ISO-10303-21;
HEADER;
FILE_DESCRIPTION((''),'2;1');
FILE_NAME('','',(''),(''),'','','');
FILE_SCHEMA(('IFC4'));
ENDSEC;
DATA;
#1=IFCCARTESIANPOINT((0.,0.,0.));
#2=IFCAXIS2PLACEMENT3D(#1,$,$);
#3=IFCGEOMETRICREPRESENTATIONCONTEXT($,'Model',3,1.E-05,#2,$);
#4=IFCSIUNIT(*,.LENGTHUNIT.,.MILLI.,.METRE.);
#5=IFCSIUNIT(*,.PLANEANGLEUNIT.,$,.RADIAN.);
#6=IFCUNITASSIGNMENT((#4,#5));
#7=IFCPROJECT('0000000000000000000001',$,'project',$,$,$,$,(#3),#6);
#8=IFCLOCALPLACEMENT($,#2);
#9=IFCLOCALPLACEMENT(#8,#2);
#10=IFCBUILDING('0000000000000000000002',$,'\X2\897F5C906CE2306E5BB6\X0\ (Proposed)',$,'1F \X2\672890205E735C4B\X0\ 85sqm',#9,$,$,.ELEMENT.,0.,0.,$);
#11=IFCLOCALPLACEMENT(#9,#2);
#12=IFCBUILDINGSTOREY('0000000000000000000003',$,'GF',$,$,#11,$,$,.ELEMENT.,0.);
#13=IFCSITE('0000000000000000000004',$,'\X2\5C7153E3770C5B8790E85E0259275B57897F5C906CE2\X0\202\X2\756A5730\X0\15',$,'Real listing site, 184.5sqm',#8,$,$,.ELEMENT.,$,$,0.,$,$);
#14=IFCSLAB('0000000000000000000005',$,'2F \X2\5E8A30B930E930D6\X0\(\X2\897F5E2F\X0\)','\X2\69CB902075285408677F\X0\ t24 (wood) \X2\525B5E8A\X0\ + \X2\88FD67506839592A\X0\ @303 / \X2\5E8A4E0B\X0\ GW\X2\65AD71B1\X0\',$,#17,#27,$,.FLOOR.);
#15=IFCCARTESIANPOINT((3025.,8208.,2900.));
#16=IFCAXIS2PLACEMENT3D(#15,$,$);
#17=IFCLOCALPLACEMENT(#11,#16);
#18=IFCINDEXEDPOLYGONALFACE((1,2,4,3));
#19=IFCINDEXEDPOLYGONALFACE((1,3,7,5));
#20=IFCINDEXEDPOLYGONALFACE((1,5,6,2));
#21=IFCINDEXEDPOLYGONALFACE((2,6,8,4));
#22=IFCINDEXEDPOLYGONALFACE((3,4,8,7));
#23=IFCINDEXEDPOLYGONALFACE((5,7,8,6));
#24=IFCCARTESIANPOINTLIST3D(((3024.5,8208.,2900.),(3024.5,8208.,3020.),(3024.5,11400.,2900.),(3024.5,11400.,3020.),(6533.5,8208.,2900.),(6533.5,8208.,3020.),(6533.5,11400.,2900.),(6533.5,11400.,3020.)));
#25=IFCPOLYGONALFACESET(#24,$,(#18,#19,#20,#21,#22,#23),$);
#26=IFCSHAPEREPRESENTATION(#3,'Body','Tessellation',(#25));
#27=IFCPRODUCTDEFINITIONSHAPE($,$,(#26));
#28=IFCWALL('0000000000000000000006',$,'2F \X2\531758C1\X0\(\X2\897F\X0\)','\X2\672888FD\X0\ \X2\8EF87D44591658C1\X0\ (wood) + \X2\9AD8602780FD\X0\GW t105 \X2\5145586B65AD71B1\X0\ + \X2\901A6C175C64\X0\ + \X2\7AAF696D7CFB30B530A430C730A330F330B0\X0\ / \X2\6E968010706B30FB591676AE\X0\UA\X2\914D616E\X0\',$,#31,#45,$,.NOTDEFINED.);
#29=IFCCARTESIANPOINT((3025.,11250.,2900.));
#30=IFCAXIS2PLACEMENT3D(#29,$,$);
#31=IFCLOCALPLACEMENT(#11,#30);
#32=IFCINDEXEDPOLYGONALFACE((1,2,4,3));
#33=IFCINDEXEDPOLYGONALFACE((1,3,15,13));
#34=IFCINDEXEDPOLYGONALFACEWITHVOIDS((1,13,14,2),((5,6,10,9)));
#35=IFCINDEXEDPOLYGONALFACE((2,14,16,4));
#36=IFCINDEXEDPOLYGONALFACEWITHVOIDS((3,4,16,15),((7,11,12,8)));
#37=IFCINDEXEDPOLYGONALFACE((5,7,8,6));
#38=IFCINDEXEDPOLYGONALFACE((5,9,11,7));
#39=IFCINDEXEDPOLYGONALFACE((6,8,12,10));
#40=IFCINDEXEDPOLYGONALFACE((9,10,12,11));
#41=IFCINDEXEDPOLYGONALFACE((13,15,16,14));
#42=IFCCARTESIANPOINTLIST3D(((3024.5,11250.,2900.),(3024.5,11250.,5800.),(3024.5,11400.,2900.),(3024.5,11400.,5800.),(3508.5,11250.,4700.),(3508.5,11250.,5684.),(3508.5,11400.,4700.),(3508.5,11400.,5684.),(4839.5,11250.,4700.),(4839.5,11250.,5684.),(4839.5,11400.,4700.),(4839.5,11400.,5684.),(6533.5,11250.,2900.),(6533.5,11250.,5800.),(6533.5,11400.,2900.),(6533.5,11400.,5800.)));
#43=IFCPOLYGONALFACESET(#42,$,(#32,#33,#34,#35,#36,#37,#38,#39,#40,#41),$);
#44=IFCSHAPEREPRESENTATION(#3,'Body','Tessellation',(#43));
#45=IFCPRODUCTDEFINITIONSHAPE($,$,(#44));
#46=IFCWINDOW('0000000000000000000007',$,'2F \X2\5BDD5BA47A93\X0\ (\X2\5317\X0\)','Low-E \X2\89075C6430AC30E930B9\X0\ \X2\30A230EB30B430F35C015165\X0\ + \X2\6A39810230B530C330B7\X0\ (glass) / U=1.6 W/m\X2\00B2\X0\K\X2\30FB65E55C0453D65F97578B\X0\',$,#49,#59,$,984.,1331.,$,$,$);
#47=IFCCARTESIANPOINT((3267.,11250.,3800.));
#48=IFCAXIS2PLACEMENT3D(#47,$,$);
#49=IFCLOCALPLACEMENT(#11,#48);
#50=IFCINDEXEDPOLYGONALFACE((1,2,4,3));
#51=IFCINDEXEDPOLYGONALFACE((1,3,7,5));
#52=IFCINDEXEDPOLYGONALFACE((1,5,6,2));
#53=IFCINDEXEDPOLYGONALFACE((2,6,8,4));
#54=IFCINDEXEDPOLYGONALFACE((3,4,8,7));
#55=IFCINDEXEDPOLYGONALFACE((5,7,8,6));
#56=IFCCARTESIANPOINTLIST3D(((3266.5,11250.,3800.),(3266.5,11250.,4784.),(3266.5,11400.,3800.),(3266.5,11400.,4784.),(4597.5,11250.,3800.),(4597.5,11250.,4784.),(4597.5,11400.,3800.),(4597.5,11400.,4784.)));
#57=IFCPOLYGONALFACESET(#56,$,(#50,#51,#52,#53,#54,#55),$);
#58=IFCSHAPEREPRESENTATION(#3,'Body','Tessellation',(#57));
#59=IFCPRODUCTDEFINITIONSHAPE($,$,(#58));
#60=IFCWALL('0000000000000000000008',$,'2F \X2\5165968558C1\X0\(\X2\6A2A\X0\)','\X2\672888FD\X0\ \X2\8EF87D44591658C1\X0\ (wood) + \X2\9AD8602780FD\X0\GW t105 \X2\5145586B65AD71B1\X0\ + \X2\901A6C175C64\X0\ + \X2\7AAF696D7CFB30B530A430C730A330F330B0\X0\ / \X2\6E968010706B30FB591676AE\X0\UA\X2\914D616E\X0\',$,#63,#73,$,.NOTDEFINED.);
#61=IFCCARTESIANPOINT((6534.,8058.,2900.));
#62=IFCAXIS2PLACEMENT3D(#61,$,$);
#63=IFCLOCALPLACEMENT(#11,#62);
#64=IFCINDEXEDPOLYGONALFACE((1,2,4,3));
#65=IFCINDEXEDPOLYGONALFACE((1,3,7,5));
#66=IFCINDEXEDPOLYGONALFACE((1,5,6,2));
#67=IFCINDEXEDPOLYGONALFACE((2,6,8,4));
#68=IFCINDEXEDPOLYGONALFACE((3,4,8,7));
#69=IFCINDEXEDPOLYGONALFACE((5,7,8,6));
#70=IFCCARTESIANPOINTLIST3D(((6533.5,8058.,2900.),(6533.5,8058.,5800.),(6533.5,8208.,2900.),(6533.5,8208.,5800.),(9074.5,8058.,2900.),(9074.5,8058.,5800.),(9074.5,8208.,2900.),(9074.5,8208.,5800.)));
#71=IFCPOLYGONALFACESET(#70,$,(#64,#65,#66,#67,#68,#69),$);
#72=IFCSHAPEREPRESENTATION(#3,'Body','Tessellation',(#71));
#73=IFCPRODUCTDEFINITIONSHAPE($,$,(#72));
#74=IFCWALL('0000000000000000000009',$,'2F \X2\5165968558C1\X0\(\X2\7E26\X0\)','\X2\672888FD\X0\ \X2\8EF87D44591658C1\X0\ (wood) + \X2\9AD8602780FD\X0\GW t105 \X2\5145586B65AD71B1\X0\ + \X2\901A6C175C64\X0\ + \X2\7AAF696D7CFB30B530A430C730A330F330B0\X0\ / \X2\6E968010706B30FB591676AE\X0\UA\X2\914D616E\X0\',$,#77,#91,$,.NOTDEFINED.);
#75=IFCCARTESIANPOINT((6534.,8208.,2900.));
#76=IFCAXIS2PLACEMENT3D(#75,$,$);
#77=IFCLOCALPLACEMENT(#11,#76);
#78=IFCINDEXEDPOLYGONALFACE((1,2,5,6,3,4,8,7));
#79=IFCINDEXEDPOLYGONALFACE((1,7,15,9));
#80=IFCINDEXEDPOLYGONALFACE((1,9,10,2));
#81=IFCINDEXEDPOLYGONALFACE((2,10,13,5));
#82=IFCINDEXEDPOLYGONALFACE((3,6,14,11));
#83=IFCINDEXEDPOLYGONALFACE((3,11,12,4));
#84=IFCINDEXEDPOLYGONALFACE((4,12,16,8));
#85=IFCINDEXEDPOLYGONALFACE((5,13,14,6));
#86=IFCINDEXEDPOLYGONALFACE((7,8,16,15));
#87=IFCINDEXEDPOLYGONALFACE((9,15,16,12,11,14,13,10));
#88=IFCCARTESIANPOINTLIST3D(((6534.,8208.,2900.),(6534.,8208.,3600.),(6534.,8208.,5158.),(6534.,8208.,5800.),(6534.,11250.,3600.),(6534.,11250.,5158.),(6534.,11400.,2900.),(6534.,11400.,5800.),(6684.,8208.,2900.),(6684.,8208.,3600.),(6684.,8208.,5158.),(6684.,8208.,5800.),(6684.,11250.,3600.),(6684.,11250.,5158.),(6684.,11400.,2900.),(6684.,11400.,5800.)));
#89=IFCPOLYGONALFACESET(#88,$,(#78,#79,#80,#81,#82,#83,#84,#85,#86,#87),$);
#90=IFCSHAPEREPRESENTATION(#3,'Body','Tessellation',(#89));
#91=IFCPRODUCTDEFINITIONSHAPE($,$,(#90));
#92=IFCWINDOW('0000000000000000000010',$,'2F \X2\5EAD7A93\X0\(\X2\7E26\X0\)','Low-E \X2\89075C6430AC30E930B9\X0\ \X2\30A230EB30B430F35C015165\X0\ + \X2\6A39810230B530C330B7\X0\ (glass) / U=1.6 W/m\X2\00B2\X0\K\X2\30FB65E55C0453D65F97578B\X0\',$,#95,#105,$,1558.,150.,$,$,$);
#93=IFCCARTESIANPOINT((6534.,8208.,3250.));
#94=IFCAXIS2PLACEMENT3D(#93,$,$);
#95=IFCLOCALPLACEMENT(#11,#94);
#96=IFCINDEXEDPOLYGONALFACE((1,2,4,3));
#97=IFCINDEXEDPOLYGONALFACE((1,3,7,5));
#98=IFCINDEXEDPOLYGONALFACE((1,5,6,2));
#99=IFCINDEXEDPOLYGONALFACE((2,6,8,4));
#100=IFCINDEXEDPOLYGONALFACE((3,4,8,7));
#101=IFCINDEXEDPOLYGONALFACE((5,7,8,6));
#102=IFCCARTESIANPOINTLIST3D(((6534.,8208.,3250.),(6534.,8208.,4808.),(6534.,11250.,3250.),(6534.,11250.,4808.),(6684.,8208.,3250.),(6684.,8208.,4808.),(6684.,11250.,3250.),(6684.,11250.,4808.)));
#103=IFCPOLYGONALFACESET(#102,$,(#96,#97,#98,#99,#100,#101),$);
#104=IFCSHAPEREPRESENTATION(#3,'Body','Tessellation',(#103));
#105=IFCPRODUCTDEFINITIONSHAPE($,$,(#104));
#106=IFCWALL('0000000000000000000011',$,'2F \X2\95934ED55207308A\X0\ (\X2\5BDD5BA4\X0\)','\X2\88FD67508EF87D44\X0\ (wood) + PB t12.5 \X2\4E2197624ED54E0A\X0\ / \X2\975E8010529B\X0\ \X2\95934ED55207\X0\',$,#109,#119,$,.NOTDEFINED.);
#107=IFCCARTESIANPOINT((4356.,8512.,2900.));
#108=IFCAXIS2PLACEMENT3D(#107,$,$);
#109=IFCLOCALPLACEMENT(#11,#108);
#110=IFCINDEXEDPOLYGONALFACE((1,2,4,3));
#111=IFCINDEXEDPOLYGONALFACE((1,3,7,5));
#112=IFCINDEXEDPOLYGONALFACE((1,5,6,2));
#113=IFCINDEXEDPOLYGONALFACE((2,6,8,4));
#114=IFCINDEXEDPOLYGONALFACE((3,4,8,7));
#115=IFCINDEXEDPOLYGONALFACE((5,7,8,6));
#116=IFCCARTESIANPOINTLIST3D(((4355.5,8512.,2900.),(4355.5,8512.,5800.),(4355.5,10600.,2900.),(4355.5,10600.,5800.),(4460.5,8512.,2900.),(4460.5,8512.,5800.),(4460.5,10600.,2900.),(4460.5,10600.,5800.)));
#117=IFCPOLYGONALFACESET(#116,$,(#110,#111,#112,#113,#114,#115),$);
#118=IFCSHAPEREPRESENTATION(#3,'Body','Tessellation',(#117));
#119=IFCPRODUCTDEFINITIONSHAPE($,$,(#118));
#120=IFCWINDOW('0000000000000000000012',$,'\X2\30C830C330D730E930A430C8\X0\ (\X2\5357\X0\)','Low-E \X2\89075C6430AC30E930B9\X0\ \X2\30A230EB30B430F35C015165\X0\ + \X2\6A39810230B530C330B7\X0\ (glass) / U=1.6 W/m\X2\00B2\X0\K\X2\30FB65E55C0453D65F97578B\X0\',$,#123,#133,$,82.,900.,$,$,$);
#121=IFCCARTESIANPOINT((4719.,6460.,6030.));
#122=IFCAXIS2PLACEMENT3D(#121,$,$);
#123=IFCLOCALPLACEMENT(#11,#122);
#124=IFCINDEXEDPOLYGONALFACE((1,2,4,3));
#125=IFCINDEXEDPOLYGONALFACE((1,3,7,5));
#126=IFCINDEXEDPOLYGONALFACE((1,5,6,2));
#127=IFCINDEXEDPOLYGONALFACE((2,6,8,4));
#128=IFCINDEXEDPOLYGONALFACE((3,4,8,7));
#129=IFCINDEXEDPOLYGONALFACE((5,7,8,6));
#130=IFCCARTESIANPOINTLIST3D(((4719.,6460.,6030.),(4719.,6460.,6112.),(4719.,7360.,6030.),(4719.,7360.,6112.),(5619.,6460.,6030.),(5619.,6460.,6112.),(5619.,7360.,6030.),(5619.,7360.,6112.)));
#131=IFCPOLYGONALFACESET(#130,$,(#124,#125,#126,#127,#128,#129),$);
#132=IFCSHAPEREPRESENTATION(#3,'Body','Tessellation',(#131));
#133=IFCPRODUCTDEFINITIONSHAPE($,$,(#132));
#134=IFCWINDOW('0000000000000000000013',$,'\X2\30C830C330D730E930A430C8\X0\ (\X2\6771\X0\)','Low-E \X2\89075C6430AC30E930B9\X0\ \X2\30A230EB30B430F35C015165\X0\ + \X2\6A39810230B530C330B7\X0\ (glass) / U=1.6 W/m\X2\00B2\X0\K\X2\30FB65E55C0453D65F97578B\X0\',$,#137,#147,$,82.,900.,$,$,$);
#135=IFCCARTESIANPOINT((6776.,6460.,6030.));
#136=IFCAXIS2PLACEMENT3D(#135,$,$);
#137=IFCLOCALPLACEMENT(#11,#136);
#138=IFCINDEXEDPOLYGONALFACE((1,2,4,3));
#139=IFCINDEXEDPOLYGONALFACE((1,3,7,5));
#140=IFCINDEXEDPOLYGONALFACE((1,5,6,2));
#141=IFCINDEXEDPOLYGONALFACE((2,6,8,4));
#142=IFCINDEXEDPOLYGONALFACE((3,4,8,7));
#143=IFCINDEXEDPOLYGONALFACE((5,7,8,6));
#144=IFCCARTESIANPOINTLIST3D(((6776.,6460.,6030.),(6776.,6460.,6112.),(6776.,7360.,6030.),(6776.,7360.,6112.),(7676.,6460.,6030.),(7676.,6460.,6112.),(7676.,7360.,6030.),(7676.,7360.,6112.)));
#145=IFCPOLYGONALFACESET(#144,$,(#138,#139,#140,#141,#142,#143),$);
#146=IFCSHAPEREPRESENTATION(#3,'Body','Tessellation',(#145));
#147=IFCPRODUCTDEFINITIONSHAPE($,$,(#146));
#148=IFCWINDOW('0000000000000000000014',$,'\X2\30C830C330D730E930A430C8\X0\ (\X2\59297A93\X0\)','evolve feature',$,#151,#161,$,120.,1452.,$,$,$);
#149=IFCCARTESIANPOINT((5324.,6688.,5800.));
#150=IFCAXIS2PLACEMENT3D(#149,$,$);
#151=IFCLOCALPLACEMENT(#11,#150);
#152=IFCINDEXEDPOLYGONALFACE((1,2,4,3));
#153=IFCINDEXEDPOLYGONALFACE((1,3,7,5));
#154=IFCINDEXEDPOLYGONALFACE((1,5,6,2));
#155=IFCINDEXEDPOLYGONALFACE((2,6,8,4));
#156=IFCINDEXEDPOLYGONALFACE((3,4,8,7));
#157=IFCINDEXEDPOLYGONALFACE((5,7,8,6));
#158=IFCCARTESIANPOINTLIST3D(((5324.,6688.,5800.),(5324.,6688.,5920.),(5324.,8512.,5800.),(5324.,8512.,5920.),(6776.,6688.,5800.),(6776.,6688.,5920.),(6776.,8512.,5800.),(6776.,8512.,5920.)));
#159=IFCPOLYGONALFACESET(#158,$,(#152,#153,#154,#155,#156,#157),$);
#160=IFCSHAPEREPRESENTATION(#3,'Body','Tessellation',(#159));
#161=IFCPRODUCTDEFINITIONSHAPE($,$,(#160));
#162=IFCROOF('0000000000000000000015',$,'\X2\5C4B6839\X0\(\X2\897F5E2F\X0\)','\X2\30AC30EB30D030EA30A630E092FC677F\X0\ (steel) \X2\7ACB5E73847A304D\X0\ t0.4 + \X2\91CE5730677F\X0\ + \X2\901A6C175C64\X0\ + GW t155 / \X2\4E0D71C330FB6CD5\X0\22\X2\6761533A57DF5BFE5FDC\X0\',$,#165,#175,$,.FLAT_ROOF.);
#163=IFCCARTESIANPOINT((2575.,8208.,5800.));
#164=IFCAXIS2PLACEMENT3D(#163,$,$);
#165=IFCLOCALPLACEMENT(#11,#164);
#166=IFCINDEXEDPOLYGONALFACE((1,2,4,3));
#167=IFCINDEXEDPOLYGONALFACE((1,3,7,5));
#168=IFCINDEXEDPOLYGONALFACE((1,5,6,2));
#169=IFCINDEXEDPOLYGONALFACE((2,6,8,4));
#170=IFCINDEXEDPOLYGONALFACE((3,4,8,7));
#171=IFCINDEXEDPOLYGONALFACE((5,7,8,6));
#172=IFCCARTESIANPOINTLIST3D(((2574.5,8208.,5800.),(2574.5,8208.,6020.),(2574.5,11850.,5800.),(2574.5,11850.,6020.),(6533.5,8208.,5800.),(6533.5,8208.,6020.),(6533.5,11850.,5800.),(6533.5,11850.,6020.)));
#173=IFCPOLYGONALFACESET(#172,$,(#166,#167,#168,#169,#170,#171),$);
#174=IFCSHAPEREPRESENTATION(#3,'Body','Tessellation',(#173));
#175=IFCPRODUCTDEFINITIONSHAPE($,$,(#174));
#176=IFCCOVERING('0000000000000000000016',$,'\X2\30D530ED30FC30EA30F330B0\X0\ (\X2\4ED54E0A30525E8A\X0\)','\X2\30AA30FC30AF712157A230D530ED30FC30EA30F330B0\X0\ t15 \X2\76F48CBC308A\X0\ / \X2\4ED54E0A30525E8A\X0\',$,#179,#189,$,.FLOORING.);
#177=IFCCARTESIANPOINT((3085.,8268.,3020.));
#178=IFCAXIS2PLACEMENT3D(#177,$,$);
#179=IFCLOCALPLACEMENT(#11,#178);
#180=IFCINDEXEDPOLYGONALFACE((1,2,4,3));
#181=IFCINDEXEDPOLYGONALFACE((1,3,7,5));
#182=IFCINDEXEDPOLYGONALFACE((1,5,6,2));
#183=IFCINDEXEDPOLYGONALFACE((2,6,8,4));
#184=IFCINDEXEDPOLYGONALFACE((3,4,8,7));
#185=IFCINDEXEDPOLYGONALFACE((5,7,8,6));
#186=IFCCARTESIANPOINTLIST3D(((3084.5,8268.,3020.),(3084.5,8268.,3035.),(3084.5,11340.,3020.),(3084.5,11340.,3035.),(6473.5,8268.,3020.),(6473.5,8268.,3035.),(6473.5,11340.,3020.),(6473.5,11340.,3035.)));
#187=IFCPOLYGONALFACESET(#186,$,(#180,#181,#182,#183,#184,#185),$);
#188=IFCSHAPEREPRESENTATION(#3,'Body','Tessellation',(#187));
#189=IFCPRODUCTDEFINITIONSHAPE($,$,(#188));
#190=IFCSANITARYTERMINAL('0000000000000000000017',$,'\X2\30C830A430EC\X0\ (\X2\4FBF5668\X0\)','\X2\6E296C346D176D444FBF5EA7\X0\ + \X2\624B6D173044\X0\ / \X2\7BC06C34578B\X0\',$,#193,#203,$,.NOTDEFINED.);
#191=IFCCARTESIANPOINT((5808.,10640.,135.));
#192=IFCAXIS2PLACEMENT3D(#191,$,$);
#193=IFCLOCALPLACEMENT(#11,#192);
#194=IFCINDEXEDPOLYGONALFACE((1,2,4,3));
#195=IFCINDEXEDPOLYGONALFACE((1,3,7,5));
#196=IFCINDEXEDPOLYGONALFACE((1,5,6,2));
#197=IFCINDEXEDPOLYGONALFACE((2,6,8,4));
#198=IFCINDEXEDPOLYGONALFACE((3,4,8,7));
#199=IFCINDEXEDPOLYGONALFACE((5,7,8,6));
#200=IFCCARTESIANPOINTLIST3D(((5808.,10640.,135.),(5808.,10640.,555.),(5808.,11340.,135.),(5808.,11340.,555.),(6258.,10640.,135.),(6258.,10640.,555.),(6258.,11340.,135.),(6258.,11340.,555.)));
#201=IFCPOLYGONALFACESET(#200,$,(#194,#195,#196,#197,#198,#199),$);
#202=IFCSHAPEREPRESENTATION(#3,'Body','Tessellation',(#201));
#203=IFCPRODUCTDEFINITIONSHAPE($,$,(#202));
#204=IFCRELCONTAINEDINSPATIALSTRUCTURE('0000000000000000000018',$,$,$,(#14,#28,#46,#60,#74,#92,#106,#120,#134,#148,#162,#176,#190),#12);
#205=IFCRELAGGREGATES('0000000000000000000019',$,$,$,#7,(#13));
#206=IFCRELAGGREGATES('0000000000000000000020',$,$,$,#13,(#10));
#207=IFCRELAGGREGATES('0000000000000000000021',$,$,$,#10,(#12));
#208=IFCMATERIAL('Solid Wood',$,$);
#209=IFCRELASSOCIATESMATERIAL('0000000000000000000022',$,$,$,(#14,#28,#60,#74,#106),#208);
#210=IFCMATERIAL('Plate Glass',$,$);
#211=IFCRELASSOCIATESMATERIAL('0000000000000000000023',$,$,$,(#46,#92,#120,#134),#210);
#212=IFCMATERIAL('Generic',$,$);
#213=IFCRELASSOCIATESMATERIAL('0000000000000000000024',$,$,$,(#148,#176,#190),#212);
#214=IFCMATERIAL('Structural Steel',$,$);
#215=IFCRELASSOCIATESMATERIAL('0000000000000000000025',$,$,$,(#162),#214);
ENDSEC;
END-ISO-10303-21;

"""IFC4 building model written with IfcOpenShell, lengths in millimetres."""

from ifc_helpers import new_model, si_unit, frame, frame_2d, origin, place, context, project, spatial, rectangle, extrude, material, element, fill, save


model = new_model("IFC4")

# Units and contexts
model_context = context("Model", 3, precision=1e-05, world=origin())
ifc_project = project(units=[si_unit("LENGTHUNIT", "METRE", prefix="MILLI"), si_unit("PLANEANGLEUNIT", "RADIAN")], contexts=[model_context])

# Site, building, storey
site_placement = place(None, origin())
site = spatial("IfcSite", under=ifc_project, at=site_placement, Name="山口県宇部市大字西岐波202番地15", ObjectType="Real listing site, 184.5sqm", CompositionType="ELEMENT", RefElevation=0.0)
building_placement = place(site_placement, origin())
building = spatial("IfcBuilding", under=site, at=building_placement, Name="西岐波の家 (Proposed)", ObjectType="1F 木造平屋 85sqm", CompositionType="ELEMENT", ElevationOfRefHeight=0.0, ElevationOfTerrain=0.0)
storey_placement = place(building_placement, origin())
storey = spatial("IfcBuildingStorey", under=building, at=storey_placement, Name="GF", CompositionType="ELEMENT", Elevation=0.0)

# Slab
ifc_material_1 = material(Name="Solid Wood")
slab_placement = place(storey_placement, frame((3025.0, 8208.0, 2900.0)))
element("IfcSlab", 1, at=slab_placement, inside=storey, material=ifc_material_1, Name="2F 床スラブ(西帯)", Description="構造用合板 t24 (wood) 剛床 + 製材根太 @303 / 床下 GW断熱", PredefinedType="FLOOR", context=model_context, shape_type="SweptSolid", body=[
    extrude(rectangle(XDim=3509.0, YDim=3192.0, at=frame_2d((1754.0, 1596.0))), frame((3025.0, 8208.0, 2900.0)), (0.0, 0.0, 1.0), 120.0),
])

# Wall, opening, window
wall_1_placement = place(storey_placement, frame((3025.0, 11250.0, 2900.0)))
wall_1 = element("IfcWall", 2, at=wall_1_placement, inside=storey, material=ifc_material_1, Name="2F 北壁(西)", Description="木製 軸組外壁 (wood) + 高性能GW t105 充填断熱 + 通気層 + 窯業系サイディング / 準耐火・外皮UA配慮", PredefinedType="NOTDEFINED", context=model_context, shape_type="SweptSolid", body=[
    extrude(rectangle(XDim=3509.0, YDim=150.0, at=frame_2d((1754.0, 75.0))), frame((3025.0, 11250.0, 2900.0)), (0.0, 0.0, 1.0), 2900.0),
])
opening_1_placement = place(storey_placement, frame((3267.0, 11250.0, 3800.0)))
opening_1 = element("IfcOpeningElement", 3, at=opening_1_placement, cuts=wall_1, PredefinedType="NOTDEFINED", context=model_context, shape_type="SweptSolid", body=[
    extrude(rectangle(XDim=1331.0, YDim=150.0, at=frame_2d((665.0, 75.0))), frame((3267.0, 11250.0, 3800.0)), (0.0, 0.0, 1.0), 984.0),
])
ifc_material_2 = material(Name="Plate Glass")
window_1_placement = place(storey_placement, frame((3267.0, 11250.0, 3800.0)))
window_1 = element("IfcWindow", 4, at=window_1_placement, inside=storey, material=ifc_material_2, Name="2F 寝室窓 (北)", Description="Low-E 複層ガラス アルゴン封入 + 樹脂サッシ (glass) / U=1.6 W/m²K・日射取得型", OverallHeight=984.0, OverallWidth=1331.0, context=model_context, shape_type="SweptSolid", body=[
    extrude(rectangle(XDim=1331.0, YDim=150.0, at=frame_2d((665.0, 75.0))), frame((3267.0, 11250.0, 3800.0)), (0.0, 0.0, 1.0), 984.0),
])
fill(opening_1, window_1)

# Wall
wall_2_placement = place(storey_placement, frame((6534.0, 8058.0, 2900.0)))
element("IfcWall", 5, at=wall_2_placement, inside=storey, material=ifc_material_1, Name="2F 入隅壁(横)", Description="木製 軸組外壁 (wood) + 高性能GW t105 充填断熱 + 通気層 + 窯業系サイディング / 準耐火・外皮UA配慮", PredefinedType="NOTDEFINED", context=model_context, shape_type="SweptSolid", body=[
    extrude(rectangle(XDim=2541.0, YDim=150.0, at=frame_2d((1270.0, 75.0))), frame((6534.0, 8058.0, 2900.0)), (0.0, 0.0, 1.0), 2900.0),
])

# Wall, opening, window
wall_3_placement = place(storey_placement, frame((6534.0, 8208.0, 2900.0)))
wall_3 = element("IfcWall", 6, at=wall_3_placement, inside=storey, material=ifc_material_1, Name="2F 入隅壁(縦)", Description="木製 軸組外壁 (wood) + 高性能GW t105 充填断熱 + 通気層 + 窯業系サイディング / 準耐火・外皮UA配慮", PredefinedType="NOTDEFINED", context=model_context, shape_type="SweptSolid", body=[
    extrude(rectangle(XDim=150.0, YDim=3192.0, at=frame_2d((75.0, 1596.0))), frame((6534.0, 8208.0, 2900.0)), (0.0, 0.0, 1.0), 2900.0),
])
opening_2_placement = place(storey_placement, frame((6534.0, 8208.0, 3250.0)))
opening_2 = element("IfcOpeningElement", 7, at=opening_2_placement, cuts=wall_3, PredefinedType="NOTDEFINED", context=model_context, shape_type="SweptSolid", body=[
    extrude(rectangle(XDim=150.0, YDim=3042.0, at=frame_2d((75.0, 1521.0))), frame((6534.0, 8208.0, 3250.0)), (0.0, 0.0, 1.0), 1558.0),
])
window_2_placement = place(storey_placement, frame((6534.0, 8208.0, 3250.0)))
window_2 = element("IfcWindow", 8, at=window_2_placement, inside=storey, material=ifc_material_2, Name="2F 庭窓(縦)", Description="Low-E 複層ガラス アルゴン封入 + 樹脂サッシ (glass) / U=1.6 W/m²K・日射取得型", OverallHeight=1558.0, OverallWidth=150.0, context=model_context, shape_type="SweptSolid", body=[
    extrude(rectangle(XDim=150.0, YDim=3042.0, at=frame_2d((75.0, 1521.0))), frame((6534.0, 8208.0, 3250.0)), (0.0, 0.0, 1.0), 1558.0),
])
fill(opening_2, window_2)

# Wall
wall_4_placement = place(storey_placement, frame((4356.0, 8512.0, 2900.0)))
element("IfcWall", 9, at=wall_4_placement, inside=storey, material=ifc_material_1, Name="2F 間仕切り (寝室)", Description="製材軸組 (wood) + PB t12.5 両面仕上 / 非耐力 間仕切", PredefinedType="NOTDEFINED", context=model_context, shape_type="SweptSolid", body=[
    extrude(rectangle(XDim=105.0, YDim=2088.0, at=frame_2d((52.0, 1044.0))), frame((4356.0, 8512.0, 2900.0)), (0.0, 0.0, 1.0), 2900.0),
])

# Windows
window_3_placement = place(storey_placement, frame((4719.0, 6460.0, 6030.0)))
element("IfcWindow", 10, at=window_3_placement, inside=storey, material=ifc_material_2, Name="トップライト (南)", Description="Low-E 複層ガラス アルゴン封入 + 樹脂サッシ (glass) / U=1.6 W/m²K・日射取得型", OverallHeight=82.0, OverallWidth=900.0, context=model_context, shape_type="SweptSolid", body=[
    extrude(rectangle(XDim=900.0, YDim=900.0, at=frame_2d((450.0, 450.0))), frame((4719.0, 6460.0, 6030.0)), (0.0, 0.0, 1.0), 82.0),
])
window_4_placement = place(storey_placement, frame((6776.0, 6460.0, 6030.0)))
element("IfcWindow", 11, at=window_4_placement, inside=storey, material=ifc_material_2, Name="トップライト (東)", Description="Low-E 複層ガラス アルゴン封入 + 樹脂サッシ (glass) / U=1.6 W/m²K・日射取得型", OverallHeight=82.0, OverallWidth=900.0, context=model_context, shape_type="SweptSolid", body=[
    extrude(rectangle(XDim=900.0, YDim=900.0, at=frame_2d((450.0, 450.0))), frame((6776.0, 6460.0, 6030.0)), (0.0, 0.0, 1.0), 82.0),
])
ifc_material_3 = material(Name="Generic")
window_5_placement = place(storey_placement, frame((5324.0, 6688.0, 5800.0)))
element("IfcWindow", 12, at=window_5_placement, inside=storey, material=ifc_material_3, Name="トップライト (天窓)", Description="evolve feature", OverallHeight=120.0, OverallWidth=1452.0, context=model_context, shape_type="SweptSolid", body=[
    extrude(rectangle(XDim=1452.0, YDim=1824.0, at=frame_2d((726.0, 912.0))), frame((5324.0, 6688.0, 5800.0)), (0.0, 0.0, 1.0), 120.0),
])

# Roof
ifc_material_4 = material(Name="Structural Steel")
for number, where, name in (
    (13, (2575.0, 8208.0, 5800.0), "屋根(西帯)"),
):
    element("IfcRoof", number, at=place(storey_placement, frame(where)), inside=storey, material=ifc_material_4, Name=name, Description="ガルバリウム鋼板 (steel) 立平葺き t0.4 + 野地板 + 通気層 + GW t155 / 不燃・法22条区域対応", PredefinedType="FLAT_ROOF", context=model_context, shape_type="SweptSolid", body=[
        extrude(rectangle(XDim=3959.0, YDim=3642.0, at=frame_2d((1979.0, 1821.0))), frame((2575.0, 8208.0, 5800.0)), (0.0, 0.0, 1.0), 220.0),
    ])

# Covering
covering_placement = place(storey_placement, frame((3085.0, 8268.0, 3020.0)))
element("IfcCovering", 14, at=covering_placement, inside=storey, material=ifc_material_3, Name="フローリング (仕上げ床)", Description="オーク無垢フローリング t15 直貼り / 仕上げ床", PredefinedType="FLOORING", context=model_context, shape_type="SweptSolid", body=[
    extrude(rectangle(XDim=3389.0, YDim=3072.0, at=frame_2d((1694.0, 1536.0))), frame((3085.0, 8268.0, 3020.0)), (0.0, 0.0, 1.0), 15.0),
])

# Sanitary terminal
sanitary_terminal_placement = place(storey_placement, frame((5808.0, 10640.0, 135.0)))
element("IfcSanitaryTerminal", 15, at=sanitary_terminal_placement, inside=storey, material=ifc_material_3, Name="トイレ (便器)", Description="温水洗浄便座 + 手洗い / 節水型", PredefinedType="NOTDEFINED", context=model_context, shape_type="SweptSolid", body=[
    extrude(rectangle(XDim=450.0, YDim=700.0, at=frame_2d((225.0, 350.0))), frame((5808.0, 10640.0, 135.0)), (0.0, 0.0, 1.0), 420.0),
])

save(model, "model.ifc")
